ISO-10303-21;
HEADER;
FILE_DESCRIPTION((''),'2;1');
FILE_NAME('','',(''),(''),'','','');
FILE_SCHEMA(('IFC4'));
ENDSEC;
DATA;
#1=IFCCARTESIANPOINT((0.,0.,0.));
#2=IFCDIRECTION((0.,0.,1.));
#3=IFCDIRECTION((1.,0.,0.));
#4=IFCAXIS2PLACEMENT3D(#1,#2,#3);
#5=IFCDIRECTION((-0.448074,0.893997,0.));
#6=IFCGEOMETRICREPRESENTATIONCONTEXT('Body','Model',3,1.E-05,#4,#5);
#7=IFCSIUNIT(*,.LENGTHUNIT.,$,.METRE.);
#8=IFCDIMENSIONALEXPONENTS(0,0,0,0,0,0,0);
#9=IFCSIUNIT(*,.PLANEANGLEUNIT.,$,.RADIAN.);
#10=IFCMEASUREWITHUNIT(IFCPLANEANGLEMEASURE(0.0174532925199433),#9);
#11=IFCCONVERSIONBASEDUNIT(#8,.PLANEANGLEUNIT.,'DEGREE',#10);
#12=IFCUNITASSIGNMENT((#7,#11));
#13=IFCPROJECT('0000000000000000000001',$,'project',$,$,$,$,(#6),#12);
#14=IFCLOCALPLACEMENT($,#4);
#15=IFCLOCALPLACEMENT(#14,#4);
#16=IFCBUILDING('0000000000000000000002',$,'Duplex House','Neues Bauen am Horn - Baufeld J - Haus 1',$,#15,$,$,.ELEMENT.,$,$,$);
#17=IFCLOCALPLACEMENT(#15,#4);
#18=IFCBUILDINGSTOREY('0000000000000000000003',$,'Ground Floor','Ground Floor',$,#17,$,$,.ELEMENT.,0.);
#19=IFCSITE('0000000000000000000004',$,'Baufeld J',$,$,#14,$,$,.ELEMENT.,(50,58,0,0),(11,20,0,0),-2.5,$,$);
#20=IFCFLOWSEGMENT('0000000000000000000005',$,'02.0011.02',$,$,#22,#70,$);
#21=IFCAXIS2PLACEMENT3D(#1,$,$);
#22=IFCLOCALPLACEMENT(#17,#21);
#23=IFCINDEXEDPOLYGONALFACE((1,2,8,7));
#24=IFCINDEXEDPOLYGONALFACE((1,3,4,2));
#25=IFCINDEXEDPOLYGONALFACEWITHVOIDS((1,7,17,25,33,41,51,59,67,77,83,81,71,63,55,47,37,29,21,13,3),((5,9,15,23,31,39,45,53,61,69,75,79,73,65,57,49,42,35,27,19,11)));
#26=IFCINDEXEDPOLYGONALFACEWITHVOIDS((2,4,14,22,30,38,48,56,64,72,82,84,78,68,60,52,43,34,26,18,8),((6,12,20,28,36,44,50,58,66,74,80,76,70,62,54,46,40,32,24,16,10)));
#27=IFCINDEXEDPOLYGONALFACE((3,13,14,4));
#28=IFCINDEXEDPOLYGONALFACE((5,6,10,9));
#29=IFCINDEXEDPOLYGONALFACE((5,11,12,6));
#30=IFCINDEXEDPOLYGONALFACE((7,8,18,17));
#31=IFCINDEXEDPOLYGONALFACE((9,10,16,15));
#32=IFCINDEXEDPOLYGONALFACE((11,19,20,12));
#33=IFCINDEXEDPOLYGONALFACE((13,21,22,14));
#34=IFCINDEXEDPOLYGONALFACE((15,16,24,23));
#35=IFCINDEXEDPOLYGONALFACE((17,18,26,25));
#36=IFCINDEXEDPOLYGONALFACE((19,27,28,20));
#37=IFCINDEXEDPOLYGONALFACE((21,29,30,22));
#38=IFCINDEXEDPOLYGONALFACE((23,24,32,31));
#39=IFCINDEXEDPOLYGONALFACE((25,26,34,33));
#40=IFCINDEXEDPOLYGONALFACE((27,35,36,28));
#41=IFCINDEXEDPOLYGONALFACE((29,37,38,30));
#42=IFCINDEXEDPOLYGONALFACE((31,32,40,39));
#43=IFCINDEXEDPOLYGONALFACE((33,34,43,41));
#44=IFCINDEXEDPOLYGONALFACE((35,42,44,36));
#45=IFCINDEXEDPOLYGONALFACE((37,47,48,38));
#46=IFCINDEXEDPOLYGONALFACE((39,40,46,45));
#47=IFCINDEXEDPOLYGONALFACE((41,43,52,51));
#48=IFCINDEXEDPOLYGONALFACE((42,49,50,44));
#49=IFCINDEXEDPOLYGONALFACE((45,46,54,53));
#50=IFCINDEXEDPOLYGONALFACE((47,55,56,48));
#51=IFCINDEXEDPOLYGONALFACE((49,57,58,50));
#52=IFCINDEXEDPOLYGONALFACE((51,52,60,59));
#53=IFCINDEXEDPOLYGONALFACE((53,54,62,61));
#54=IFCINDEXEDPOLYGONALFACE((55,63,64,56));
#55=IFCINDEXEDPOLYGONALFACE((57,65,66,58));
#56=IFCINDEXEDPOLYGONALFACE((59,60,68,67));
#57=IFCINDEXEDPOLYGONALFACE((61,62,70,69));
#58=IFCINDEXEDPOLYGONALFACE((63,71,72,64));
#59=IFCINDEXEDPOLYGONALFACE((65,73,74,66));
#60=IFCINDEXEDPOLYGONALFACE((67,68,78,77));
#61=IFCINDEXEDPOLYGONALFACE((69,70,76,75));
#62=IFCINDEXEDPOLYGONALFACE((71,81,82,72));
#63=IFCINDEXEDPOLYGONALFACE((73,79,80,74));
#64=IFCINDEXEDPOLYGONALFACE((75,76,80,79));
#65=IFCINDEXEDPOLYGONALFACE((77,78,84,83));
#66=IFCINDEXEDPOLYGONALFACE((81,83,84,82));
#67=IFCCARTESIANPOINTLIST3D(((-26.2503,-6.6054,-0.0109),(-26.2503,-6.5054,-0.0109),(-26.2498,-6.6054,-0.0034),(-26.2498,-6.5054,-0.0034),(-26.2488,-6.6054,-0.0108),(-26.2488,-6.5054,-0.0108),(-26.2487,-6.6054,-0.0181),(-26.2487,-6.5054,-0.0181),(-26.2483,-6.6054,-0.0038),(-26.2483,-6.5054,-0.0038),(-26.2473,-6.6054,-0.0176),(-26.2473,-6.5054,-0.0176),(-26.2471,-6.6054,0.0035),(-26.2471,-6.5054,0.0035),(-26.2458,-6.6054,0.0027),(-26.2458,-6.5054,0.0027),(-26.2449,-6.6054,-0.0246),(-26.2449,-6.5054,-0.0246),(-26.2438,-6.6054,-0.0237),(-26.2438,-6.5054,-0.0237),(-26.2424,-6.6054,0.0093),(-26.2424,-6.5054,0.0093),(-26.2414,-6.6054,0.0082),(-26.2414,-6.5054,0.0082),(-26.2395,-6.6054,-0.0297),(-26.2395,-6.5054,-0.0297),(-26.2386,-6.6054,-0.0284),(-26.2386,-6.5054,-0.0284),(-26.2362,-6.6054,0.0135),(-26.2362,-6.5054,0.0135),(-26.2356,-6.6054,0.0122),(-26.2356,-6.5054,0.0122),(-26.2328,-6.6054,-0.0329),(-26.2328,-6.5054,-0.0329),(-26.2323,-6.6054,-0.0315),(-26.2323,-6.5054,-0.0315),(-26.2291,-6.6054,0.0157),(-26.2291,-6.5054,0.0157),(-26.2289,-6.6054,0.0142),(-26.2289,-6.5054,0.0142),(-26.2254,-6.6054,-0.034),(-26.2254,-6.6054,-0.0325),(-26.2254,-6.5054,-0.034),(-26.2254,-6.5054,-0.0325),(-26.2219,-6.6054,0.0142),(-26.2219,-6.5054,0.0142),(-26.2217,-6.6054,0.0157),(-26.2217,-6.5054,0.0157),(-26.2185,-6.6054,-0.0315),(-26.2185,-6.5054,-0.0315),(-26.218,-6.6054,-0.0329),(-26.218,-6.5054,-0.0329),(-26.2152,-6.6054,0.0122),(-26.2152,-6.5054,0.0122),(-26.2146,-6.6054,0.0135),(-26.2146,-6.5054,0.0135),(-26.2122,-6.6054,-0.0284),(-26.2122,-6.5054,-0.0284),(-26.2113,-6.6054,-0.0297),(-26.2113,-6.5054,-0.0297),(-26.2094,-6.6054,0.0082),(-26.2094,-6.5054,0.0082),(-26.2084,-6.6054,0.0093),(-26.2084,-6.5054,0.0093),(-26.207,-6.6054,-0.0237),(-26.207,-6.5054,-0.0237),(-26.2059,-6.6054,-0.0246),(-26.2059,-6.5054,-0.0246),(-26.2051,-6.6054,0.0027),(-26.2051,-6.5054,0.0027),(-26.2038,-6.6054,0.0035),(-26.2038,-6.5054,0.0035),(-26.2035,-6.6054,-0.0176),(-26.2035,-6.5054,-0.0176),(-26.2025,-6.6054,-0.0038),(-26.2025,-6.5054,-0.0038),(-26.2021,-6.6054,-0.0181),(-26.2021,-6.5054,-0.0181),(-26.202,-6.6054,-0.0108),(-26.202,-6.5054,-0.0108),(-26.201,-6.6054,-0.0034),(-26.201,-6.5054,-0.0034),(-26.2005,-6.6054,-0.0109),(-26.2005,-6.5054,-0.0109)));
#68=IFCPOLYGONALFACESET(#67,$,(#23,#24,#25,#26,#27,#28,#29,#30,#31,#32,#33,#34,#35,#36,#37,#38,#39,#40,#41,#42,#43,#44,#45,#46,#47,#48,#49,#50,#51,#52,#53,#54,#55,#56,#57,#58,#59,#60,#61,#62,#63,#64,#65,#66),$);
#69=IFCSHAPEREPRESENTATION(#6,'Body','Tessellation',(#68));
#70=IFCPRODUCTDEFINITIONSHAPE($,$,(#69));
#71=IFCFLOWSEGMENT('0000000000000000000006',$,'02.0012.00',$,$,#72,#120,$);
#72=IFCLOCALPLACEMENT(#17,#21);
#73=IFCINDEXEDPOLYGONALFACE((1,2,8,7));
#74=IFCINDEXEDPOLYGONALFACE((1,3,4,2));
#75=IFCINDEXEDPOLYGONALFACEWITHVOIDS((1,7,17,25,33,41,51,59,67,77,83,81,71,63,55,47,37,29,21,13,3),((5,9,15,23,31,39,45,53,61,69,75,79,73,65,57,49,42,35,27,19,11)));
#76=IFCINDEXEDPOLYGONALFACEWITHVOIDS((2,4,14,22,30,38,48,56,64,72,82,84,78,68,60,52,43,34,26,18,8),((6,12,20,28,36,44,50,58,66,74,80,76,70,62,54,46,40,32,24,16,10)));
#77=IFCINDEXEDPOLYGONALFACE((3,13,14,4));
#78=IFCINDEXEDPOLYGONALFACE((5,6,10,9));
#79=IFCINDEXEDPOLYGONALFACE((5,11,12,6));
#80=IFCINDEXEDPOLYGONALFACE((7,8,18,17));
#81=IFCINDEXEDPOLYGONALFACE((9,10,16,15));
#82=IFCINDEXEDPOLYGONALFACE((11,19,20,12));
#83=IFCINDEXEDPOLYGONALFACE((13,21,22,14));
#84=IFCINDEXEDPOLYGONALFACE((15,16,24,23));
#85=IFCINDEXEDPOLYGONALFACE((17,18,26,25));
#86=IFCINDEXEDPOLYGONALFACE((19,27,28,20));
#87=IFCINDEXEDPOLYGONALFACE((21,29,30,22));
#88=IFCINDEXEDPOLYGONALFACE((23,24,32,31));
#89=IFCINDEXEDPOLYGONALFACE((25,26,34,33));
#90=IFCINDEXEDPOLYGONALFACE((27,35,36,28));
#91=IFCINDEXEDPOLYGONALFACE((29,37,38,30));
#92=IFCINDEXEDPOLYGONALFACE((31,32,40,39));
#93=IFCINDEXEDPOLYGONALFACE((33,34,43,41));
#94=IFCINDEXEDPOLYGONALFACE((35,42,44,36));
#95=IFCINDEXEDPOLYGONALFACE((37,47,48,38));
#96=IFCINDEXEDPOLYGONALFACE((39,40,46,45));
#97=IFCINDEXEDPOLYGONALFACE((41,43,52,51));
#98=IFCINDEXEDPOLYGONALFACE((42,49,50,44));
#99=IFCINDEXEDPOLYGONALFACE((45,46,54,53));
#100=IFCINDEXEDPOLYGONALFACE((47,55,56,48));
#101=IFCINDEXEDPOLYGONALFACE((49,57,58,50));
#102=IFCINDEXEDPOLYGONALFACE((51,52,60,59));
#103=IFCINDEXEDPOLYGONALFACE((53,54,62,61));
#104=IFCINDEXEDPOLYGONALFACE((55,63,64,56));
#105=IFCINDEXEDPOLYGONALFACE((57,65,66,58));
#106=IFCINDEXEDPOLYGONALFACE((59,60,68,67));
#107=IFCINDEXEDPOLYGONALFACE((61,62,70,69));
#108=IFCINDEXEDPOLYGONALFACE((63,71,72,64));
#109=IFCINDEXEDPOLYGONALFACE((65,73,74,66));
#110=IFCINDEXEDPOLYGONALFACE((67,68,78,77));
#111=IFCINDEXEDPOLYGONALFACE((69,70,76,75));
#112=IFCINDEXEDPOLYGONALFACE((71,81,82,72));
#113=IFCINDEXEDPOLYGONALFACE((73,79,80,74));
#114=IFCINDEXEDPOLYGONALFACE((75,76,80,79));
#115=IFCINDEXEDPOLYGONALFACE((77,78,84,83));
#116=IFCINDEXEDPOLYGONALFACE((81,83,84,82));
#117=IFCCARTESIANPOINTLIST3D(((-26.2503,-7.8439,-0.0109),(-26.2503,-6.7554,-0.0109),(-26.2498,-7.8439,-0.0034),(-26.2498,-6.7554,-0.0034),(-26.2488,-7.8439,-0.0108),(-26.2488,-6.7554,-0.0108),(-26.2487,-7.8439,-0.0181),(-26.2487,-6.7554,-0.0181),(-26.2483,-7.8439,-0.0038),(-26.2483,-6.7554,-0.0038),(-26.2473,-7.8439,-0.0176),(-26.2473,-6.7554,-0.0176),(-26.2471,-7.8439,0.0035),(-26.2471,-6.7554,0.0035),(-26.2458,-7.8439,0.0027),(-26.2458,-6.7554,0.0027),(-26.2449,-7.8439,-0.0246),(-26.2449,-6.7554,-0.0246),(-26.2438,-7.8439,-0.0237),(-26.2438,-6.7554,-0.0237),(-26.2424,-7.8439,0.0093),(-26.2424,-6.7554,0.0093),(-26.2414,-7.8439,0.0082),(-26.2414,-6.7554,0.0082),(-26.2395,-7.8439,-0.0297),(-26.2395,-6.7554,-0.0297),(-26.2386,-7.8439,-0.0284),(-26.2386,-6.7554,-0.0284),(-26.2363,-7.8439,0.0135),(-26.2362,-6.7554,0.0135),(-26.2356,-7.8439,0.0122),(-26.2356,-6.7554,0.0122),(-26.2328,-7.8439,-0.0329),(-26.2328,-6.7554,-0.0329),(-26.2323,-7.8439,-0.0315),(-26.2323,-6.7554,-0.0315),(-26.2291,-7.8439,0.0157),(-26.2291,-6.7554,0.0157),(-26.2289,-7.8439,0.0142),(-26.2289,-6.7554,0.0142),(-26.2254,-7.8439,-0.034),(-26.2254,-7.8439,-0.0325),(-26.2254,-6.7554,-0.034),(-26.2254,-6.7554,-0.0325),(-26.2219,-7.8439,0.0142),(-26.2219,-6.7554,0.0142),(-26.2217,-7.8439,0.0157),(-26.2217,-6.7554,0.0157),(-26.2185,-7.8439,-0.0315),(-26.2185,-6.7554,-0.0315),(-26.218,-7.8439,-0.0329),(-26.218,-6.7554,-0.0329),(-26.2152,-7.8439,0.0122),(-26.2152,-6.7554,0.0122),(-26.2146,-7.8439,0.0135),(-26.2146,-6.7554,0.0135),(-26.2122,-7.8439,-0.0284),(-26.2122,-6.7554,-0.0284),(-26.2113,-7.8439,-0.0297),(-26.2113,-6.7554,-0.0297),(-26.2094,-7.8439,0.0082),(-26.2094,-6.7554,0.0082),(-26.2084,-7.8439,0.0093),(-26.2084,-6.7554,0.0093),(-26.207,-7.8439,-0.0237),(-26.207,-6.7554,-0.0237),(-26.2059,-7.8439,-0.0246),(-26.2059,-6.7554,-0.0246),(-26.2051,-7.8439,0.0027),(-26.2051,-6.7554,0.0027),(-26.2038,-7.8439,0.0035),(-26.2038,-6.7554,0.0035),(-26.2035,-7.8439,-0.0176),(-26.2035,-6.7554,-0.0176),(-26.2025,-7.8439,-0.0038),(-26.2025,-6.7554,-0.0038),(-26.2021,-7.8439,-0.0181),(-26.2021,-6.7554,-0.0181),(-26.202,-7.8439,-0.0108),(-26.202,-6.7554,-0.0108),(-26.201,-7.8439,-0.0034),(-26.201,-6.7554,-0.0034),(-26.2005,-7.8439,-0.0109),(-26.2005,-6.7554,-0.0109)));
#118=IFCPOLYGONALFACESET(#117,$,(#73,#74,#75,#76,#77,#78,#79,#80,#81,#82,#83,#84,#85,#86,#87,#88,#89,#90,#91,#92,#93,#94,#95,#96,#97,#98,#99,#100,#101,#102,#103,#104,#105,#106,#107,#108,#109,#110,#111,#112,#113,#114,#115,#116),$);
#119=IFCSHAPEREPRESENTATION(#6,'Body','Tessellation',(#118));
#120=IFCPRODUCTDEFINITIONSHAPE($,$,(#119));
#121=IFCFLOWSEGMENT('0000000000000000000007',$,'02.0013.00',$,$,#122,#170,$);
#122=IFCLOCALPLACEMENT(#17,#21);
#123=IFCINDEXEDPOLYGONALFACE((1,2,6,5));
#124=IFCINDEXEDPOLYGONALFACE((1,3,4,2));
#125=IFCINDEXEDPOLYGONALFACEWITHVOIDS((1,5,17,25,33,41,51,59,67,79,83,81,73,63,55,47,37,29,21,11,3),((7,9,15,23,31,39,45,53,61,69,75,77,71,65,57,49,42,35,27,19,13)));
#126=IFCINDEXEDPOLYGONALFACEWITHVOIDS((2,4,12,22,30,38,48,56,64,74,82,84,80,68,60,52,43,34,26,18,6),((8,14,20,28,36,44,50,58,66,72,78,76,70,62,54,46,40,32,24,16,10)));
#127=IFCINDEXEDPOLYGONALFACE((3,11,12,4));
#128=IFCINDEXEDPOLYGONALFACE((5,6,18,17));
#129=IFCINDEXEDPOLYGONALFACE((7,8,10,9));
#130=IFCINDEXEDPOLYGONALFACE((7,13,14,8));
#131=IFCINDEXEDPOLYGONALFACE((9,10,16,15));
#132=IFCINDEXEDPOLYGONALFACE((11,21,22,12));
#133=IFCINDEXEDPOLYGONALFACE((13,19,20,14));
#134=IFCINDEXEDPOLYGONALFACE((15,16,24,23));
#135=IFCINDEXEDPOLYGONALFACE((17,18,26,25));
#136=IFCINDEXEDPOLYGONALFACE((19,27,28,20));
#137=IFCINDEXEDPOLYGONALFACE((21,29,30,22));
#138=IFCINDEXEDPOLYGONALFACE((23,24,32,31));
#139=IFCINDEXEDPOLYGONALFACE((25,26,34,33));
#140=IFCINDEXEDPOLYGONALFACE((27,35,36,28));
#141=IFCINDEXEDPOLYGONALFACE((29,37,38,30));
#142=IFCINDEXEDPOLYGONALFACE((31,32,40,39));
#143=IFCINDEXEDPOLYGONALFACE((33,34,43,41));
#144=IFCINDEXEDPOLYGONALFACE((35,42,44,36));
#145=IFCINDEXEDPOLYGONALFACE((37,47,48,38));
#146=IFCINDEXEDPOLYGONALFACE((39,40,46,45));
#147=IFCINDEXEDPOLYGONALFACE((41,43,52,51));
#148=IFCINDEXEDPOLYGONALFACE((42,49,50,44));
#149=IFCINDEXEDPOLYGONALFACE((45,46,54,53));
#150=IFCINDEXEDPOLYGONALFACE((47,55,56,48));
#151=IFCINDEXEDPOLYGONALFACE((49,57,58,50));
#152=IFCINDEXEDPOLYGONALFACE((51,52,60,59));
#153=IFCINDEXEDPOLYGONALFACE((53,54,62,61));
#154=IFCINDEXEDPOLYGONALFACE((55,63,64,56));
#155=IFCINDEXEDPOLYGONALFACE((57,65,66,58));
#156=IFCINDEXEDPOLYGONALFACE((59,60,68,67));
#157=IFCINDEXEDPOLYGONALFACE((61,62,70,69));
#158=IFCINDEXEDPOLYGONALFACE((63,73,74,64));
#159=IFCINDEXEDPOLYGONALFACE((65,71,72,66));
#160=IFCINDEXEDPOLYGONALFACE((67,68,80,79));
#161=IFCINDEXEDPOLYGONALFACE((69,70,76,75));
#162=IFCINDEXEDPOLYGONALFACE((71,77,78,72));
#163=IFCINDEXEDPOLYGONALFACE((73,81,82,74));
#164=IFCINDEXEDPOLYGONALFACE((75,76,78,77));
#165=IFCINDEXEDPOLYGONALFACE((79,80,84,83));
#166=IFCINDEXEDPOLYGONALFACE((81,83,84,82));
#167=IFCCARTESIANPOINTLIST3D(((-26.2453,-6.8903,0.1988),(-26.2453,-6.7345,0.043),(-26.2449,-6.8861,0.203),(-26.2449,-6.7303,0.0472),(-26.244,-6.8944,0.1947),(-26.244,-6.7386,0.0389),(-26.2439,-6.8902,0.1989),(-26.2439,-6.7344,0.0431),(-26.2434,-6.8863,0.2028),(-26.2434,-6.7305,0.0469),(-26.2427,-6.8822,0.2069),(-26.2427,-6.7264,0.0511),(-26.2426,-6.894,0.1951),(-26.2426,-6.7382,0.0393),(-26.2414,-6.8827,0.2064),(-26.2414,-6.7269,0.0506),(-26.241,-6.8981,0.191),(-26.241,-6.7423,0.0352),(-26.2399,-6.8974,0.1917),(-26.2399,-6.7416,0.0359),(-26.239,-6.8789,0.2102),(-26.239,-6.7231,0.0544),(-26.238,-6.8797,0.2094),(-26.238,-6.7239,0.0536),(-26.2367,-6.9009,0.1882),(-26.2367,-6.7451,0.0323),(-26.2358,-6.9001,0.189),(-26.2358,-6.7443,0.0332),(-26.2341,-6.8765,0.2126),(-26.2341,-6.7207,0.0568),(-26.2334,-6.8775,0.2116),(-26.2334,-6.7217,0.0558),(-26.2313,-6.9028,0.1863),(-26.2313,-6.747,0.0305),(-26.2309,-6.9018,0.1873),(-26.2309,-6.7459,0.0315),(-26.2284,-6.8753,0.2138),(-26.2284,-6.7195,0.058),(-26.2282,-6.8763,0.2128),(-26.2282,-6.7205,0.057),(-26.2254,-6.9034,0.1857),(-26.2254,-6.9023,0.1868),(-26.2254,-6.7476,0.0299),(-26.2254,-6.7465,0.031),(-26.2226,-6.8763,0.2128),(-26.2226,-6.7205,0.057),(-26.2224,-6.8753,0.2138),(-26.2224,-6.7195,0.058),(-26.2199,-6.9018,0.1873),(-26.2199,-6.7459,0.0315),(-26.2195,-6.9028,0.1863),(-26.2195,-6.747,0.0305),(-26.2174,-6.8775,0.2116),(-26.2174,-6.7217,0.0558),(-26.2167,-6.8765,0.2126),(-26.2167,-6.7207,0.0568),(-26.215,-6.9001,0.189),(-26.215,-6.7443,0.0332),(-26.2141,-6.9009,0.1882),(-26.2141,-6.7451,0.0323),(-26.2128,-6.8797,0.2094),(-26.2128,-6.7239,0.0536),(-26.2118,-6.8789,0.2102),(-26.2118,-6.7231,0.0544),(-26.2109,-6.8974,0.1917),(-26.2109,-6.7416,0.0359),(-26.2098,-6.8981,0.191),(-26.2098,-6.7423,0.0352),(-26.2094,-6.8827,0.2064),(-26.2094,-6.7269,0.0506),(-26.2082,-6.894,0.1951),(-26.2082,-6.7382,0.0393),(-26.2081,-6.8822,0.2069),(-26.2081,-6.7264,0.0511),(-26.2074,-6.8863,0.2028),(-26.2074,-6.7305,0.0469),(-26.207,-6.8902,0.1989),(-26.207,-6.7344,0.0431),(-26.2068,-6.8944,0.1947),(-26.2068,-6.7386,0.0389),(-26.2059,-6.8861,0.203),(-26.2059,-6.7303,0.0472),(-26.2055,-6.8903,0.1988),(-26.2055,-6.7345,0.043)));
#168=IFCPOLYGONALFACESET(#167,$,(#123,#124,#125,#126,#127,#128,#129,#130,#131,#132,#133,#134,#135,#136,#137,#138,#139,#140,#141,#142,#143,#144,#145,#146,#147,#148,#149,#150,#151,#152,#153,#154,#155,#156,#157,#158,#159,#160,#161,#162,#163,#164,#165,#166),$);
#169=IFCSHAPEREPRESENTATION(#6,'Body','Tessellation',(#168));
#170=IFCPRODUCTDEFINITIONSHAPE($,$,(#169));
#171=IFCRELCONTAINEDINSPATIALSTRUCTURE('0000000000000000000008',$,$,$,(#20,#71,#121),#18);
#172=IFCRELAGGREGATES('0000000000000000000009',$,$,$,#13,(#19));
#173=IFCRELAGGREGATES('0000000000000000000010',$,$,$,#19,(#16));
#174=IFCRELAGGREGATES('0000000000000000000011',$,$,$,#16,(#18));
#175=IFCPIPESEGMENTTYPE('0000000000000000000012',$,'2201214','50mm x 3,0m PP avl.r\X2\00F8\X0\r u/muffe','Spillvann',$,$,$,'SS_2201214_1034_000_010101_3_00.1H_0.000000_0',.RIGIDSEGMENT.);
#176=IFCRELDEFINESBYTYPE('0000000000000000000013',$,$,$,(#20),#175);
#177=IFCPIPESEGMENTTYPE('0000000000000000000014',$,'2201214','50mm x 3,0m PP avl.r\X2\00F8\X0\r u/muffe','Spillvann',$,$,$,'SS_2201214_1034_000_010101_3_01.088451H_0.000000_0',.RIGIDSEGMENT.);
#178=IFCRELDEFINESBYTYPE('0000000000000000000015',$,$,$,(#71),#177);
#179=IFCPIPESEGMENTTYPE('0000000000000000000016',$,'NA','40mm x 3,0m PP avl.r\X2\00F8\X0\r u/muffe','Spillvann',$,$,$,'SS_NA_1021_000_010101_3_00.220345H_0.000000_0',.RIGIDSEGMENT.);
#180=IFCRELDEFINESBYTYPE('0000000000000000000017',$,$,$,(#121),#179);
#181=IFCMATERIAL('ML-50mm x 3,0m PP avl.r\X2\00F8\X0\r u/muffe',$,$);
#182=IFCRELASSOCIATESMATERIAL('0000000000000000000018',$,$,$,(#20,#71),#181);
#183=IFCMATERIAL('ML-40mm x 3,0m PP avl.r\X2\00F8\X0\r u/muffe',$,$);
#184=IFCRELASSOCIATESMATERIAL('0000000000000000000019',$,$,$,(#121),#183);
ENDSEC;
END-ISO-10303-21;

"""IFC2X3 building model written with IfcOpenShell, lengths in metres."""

from ifc_helpers import new_model, entity, si_unit, converted_unit, direction, frame, origin_with_axes, origin_2d_with_axis, place, context, project, spatial, hollow_circle, extrude, material, type_object, element, save


model = new_model("IFC2X3")

# Units and contexts
model_context = context("Model", 3, precision=1e-05, world=origin_with_axes(), true_north=direction((-0.448074, 0.893997, 0.0)), identifier="Body")
ifc_project = project(units=[si_unit("LENGTHUNIT", "METRE"), converted_unit("PLANEANGLEUNIT", "DEGREE", entity("IfcPlaneAngleMeasure", 0.0174532925199433), si_unit("PLANEANGLEUNIT", "RADIAN"), dimensions=[0, 0, 0, 0, 0, 0, 0])], contexts=[model_context])

# Site, building, storey
site_placement = place(None, origin_with_axes())
site = spatial("IfcSite", under=ifc_project, at=site_placement, Name="Baufeld J", CompositionType="ELEMENT", RefLatitude=(50, 58, 0, 0), RefLongitude=(11, 20, 0, 0), RefElevation=-2.5)
building_placement = place(site_placement, origin_with_axes())
building = spatial("IfcBuilding", under=site, at=building_placement, Name="Duplex House", Description="Neues Bauen am Horn - Baufeld J - Haus 1", CompositionType="ELEMENT")
storey_placement = place(building_placement, origin_with_axes())
storey = spatial("IfcBuildingStorey", under=building, at=storey_placement, Name="Ground Floor", Description="Ground Floor", CompositionType="ELEMENT", Elevation=0.0)

# Flow segments
ifc_material_1 = material(Name="ML-50mm x 3,0m PP avl.rør u/muffe")
pipe_segment_type_1 = type_object("IfcPipeSegmentType", Name="2201214", Description="50mm x 3,0m PP avl.rør u/muffe", ApplicableOccurrence="Spillvann", ElementType="SS_2201214_1034_000_010101_3_00.1H_0.000000_0", PredefinedType="RIGIDSEGMENT")
flow_segment_1_placement = place(storey_placement, frame((-26.2254, -6.5054, -0.009), z_axis=(0.0, 0.0, 1.0), x_axis=(0.0, -1.0, 0.0)))
element("IfcFlowSegment", 1, at=flow_segment_1_placement, inside=storey, type_object=pipe_segment_type_1, material=ifc_material_1, Name="02.0011.02", context=model_context, shape_type="SweptSolid", body=[
    extrude(hollow_circle(Radius=0.025, WallThickness=0.0015, at=origin_2d_with_axis()), frame((0.0, 0.0, 0.0), z_axis=(1.0, 0.0, 0.0), x_axis=(0.0, 0.0, -1.0)), (0.0, 0.0, 1.0), 0.1),
])
pipe_segment_type_2 = type_object("IfcPipeSegmentType", Name="2201214", Description="50mm x 3,0m PP avl.rør u/muffe", ApplicableOccurrence="Spillvann", ElementType="SS_2201214_1034_000_010101_3_01.088451H_0.000000_0", PredefinedType="RIGIDSEGMENT")
flow_segment_2_placement = place(storey_placement, frame((-26.2254, -6.7554, -0.009), z_axis=(0.0, 0.0, 1.0), x_axis=(0.0, -1.0, 0.0)))
element("IfcFlowSegment", 2, at=flow_segment_2_placement, inside=storey, type_object=pipe_segment_type_2, material=ifc_material_1, Name="02.0012.00", context=model_context, shape_type="SweptSolid", body=[
    extrude(hollow_circle(Radius=0.025, WallThickness=0.0015, at=origin_2d_with_axis()), frame((0.0, 0.0, 0.0), z_axis=(1.0, 0.0, 0.0), x_axis=(0.0, 0.0, -1.0)), (0.0, 0.0, 1.0), 1.0885),
])
ifc_material_2 = material(Name="ML-40mm x 3,0m PP avl.rør u/muffe")
pipe_segment_type_3 = type_object("IfcPipeSegmentType", Name="NA", Description="40mm x 3,0m PP avl.rør u/muffe", ApplicableOccurrence="Spillvann", ElementType="SS_NA_1021_000_010101_3_00.220345H_0.000000_0", PredefinedType="RIGIDSEGMENT")
flow_segment_3_placement = place(storey_placement, frame((-26.2254, -6.7334, 0.044), z_axis=(0.0, 0.707107, 0.707107), x_axis=(0.0, -0.707107, 0.707107)))
element("IfcFlowSegment", 3, at=flow_segment_3_placement, inside=storey, type_object=pipe_segment_type_3, material=ifc_material_2, Name="02.0013.00", context=model_context, shape_type="SweptSolid", body=[
    extrude(hollow_circle(Radius=0.02, WallThickness=0.0015, at=origin_2d_with_axis()), frame((0.0, 0.0, 0.0), z_axis=(1.0, 0.0, 0.0), x_axis=(0.0, 0.0, -1.0)), (0.0, 0.0, 1.0), 0.2203),
])

save(model, "model.ifc")
